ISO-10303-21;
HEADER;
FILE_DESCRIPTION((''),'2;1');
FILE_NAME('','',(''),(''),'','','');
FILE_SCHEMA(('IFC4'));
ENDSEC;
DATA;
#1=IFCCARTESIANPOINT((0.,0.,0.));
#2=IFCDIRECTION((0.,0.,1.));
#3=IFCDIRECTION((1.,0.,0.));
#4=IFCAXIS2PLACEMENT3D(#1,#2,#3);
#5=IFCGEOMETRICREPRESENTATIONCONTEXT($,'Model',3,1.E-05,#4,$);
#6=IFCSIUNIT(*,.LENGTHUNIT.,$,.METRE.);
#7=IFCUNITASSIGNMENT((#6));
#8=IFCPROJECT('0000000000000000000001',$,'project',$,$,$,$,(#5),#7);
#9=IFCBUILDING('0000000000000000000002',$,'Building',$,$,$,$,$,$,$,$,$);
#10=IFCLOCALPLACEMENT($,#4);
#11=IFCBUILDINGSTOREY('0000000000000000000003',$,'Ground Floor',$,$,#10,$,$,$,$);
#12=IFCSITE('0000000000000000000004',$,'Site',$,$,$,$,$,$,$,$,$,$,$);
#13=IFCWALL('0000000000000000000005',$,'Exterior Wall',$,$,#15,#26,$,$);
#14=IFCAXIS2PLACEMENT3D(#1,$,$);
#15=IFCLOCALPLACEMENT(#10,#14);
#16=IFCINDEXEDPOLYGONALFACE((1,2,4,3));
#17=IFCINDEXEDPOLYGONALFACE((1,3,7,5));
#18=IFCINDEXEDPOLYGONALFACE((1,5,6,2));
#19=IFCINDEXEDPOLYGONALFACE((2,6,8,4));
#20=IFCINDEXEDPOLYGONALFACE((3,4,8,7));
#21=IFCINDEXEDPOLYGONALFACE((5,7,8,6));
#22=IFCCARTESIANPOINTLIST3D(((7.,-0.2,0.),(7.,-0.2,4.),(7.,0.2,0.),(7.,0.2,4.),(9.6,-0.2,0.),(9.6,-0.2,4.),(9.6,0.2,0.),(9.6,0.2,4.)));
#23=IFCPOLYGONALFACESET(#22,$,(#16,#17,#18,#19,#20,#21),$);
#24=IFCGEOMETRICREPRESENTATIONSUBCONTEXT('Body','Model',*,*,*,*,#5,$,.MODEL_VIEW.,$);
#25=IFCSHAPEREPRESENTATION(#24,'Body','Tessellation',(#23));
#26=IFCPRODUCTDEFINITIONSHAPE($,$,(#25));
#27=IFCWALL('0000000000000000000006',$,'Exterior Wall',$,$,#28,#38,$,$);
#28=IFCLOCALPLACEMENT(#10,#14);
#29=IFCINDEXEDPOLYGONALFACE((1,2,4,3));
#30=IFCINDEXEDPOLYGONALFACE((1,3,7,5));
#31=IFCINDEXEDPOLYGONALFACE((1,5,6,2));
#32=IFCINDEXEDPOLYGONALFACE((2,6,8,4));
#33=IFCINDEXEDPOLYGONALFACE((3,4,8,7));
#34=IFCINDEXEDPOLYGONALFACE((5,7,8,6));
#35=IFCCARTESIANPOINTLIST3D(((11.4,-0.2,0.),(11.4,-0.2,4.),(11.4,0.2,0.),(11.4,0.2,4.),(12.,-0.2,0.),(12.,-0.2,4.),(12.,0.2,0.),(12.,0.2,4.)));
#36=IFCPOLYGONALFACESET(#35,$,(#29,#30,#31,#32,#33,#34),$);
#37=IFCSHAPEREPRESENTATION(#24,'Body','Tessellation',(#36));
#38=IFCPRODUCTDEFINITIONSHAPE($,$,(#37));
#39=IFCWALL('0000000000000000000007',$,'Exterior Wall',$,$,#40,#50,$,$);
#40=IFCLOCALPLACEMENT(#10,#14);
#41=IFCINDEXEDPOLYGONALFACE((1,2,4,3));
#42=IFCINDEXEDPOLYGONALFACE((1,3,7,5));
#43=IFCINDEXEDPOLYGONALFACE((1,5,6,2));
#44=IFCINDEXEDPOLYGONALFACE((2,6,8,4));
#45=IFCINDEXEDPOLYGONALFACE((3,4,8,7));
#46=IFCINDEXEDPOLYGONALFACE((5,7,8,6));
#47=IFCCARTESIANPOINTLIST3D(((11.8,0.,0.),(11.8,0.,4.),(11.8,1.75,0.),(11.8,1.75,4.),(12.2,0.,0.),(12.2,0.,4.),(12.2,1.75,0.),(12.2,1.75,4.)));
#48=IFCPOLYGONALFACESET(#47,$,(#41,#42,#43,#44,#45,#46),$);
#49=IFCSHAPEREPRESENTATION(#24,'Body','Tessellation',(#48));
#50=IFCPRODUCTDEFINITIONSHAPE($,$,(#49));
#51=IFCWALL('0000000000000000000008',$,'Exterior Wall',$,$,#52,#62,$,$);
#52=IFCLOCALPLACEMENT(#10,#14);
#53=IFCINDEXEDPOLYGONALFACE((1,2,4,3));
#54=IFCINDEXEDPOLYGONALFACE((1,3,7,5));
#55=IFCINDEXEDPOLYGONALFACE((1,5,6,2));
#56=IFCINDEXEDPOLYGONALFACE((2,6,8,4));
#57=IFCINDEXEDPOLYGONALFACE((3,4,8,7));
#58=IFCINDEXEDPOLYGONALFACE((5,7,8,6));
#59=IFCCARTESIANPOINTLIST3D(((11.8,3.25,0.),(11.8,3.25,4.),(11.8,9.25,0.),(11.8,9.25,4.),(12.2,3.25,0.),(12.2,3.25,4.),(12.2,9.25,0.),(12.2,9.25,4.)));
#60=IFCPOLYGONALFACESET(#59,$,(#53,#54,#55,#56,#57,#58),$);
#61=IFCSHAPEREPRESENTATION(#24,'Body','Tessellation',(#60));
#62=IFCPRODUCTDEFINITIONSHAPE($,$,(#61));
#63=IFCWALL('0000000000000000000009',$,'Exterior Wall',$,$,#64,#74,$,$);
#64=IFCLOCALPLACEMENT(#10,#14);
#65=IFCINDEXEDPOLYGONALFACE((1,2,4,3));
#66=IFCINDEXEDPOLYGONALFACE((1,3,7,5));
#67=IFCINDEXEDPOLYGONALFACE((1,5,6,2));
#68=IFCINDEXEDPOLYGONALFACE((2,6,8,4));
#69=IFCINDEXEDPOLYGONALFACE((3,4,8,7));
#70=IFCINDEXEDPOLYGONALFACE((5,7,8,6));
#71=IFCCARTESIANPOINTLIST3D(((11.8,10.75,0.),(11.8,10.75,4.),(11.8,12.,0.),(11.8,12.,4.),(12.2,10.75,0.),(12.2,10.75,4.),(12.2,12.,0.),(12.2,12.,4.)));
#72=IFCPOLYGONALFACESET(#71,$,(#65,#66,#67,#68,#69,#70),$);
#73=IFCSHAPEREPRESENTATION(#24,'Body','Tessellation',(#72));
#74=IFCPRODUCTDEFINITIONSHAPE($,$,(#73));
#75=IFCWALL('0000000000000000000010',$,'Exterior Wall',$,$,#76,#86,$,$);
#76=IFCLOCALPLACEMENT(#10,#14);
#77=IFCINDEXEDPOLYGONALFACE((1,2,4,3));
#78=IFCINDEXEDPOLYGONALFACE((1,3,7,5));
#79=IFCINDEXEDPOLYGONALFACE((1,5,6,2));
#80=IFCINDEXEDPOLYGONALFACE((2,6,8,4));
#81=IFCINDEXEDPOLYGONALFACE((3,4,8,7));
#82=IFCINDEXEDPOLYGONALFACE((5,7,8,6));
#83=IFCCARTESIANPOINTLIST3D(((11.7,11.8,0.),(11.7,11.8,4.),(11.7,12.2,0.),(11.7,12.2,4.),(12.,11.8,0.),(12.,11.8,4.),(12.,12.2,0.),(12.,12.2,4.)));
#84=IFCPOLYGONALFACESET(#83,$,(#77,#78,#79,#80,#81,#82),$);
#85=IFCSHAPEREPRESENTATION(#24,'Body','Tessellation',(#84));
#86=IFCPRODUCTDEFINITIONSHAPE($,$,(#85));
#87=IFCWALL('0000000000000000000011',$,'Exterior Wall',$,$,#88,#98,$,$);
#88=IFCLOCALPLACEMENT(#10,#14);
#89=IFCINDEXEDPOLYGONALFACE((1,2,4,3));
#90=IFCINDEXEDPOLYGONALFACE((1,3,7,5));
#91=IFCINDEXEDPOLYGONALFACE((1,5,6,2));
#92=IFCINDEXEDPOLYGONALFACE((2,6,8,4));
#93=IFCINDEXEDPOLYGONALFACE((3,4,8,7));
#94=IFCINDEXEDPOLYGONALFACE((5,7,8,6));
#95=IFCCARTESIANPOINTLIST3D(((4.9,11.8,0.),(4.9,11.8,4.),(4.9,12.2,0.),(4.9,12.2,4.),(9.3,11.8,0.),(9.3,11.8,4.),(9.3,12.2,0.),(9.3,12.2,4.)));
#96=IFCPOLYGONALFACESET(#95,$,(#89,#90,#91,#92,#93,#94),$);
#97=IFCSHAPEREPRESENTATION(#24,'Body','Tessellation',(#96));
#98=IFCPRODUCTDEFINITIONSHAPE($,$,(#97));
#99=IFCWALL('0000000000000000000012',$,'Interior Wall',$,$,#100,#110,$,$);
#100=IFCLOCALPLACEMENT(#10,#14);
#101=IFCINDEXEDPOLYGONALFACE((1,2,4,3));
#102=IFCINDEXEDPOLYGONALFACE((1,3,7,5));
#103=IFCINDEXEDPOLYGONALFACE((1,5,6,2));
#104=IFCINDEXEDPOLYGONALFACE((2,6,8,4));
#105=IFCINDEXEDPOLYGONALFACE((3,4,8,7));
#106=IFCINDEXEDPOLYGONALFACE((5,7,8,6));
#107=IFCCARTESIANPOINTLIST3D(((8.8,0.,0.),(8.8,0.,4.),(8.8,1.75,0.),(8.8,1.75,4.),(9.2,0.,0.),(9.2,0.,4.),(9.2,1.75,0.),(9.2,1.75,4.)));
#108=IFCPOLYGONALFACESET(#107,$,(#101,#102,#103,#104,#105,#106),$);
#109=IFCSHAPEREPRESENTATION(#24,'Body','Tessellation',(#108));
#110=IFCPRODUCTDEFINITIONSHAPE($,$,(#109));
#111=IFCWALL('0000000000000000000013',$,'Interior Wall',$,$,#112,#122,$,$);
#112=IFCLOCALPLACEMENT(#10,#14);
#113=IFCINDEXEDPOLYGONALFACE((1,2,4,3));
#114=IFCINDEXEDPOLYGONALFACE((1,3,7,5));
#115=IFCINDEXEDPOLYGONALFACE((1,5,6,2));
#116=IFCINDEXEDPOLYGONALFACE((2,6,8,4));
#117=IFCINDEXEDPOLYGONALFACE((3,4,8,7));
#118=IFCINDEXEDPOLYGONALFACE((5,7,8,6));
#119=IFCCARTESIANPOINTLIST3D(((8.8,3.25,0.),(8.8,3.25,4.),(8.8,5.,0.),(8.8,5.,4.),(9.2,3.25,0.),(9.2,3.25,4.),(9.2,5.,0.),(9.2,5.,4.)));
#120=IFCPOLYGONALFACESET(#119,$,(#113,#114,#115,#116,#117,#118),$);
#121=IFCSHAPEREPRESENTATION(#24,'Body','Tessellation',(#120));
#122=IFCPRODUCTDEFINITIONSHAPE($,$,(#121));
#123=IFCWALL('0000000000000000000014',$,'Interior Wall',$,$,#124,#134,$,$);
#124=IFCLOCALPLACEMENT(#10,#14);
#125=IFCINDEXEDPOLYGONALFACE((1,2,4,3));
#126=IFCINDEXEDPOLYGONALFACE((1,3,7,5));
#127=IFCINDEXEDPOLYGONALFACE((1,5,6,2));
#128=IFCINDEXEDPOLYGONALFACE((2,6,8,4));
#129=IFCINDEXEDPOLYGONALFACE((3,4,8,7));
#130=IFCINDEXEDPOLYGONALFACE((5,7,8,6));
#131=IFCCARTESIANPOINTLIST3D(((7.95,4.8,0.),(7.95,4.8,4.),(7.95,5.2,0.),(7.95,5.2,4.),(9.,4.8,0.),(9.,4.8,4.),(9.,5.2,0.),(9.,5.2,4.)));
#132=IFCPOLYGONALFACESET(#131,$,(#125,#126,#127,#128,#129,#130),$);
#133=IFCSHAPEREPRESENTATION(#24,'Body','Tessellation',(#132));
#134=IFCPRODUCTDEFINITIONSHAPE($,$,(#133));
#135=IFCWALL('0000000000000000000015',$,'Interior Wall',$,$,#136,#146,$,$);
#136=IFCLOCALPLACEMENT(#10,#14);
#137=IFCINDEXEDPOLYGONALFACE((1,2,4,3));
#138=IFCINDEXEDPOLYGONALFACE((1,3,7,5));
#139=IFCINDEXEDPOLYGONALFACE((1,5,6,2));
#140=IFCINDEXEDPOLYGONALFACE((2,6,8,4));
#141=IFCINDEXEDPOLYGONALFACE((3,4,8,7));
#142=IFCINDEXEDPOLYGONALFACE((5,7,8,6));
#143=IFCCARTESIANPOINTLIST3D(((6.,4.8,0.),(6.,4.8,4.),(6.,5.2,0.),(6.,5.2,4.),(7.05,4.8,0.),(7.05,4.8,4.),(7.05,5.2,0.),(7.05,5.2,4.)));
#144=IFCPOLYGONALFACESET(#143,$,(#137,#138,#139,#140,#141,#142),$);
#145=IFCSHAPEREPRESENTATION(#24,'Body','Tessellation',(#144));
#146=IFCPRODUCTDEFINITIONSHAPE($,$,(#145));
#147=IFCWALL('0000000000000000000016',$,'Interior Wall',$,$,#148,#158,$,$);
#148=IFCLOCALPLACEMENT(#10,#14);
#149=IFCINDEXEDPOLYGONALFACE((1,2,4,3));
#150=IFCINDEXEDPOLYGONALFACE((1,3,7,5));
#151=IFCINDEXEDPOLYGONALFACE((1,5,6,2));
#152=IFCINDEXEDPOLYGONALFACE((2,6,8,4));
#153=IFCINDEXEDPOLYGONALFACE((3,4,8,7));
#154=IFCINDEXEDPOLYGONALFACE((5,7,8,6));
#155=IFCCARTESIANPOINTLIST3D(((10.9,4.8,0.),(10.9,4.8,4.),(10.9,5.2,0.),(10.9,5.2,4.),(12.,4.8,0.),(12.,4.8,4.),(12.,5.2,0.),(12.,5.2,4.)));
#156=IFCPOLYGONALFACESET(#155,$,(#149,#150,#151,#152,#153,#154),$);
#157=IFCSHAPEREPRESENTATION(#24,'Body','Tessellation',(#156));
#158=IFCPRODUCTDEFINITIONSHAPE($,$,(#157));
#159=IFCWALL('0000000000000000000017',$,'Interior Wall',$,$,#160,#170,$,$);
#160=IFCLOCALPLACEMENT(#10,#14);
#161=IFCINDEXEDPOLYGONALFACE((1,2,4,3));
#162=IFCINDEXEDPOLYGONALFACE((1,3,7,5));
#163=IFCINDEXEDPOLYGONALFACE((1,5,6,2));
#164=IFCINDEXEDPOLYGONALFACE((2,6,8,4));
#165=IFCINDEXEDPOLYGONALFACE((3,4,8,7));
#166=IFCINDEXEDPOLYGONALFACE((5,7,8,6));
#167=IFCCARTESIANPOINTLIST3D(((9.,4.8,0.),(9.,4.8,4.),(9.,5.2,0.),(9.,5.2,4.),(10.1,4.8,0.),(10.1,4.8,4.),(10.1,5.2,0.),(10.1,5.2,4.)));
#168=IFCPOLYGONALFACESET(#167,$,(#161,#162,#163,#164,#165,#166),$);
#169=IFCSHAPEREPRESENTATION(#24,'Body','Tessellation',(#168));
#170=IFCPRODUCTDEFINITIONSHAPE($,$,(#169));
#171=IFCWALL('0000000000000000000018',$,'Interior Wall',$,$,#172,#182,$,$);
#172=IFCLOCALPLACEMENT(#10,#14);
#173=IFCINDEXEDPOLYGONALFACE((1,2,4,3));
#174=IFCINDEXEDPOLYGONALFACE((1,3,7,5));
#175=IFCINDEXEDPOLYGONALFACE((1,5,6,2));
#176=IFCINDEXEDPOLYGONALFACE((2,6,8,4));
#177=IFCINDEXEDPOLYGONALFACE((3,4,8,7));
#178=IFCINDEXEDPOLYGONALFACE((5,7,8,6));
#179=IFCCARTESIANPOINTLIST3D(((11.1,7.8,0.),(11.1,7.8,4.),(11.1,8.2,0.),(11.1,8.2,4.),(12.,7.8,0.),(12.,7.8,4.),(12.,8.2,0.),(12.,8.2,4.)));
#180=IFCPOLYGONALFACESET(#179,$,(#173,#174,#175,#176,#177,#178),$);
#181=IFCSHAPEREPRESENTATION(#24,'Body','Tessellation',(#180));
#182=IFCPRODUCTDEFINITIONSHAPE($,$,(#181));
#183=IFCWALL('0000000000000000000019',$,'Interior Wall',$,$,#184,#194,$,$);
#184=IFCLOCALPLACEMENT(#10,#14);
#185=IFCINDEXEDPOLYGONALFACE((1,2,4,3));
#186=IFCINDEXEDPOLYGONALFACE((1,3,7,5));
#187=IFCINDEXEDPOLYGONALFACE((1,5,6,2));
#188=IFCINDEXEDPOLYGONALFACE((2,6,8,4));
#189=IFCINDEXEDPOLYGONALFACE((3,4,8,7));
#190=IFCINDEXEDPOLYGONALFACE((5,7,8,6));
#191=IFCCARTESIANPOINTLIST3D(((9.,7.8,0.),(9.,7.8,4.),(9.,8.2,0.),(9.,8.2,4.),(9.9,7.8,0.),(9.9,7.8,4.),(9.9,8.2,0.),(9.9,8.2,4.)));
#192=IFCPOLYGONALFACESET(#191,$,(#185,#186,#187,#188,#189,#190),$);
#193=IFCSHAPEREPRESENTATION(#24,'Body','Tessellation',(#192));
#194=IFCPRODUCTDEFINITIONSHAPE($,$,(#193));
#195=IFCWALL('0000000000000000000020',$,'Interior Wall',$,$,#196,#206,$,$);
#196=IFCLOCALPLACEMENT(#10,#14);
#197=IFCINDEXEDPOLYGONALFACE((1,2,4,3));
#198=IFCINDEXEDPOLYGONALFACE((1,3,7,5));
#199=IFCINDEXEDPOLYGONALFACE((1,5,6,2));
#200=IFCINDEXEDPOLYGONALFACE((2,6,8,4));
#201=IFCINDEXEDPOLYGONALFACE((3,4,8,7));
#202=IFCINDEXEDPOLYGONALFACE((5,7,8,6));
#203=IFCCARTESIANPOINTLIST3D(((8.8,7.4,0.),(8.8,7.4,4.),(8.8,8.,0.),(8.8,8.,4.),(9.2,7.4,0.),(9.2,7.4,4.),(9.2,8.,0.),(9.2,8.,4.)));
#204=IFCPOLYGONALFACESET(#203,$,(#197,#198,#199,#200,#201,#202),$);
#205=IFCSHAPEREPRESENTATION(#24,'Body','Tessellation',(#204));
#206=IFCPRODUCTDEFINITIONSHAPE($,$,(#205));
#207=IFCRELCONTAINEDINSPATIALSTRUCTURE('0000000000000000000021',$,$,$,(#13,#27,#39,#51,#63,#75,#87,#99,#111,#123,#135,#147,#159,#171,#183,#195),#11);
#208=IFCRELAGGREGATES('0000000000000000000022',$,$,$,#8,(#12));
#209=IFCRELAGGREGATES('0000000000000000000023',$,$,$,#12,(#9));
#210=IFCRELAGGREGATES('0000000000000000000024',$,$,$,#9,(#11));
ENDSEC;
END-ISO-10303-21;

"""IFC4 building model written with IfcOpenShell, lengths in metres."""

from ifc_helpers import new_model, si_unit, frame, origin_with_axes, place, context, subcontext, project, spatial, indexed_curve, outline, extrude, element, save


model = new_model("IFC4")

# Units and contexts
model_context = context("Model", 3, precision=1e-05, world=origin_with_axes())
body_context = subcontext(model_context, "Body", "Model", "MODEL_VIEW")
ifc_project = project(units=[si_unit("LENGTHUNIT", "METRE")], contexts=[model_context])

# Site, building, storey
site = spatial("IfcSite", under=ifc_project, Name="Site")
building = spatial("IfcBuilding", under=site, Name="Building")
storey_placement = place(None, origin_with_axes())
storey = spatial("IfcBuildingStorey", under=building, at=storey_placement, Name="Ground Floor")

# Walls
wall_1_placement = place(storey_placement, frame((7.0, 0.0, 0.0), z_axis=(0.0, 0.0, 1.0), x_axis=(1.0, 0.0, 0.0)))
element("IfcWall", 1, at=wall_1_placement, inside=storey, Name="Exterior Wall", context=body_context, shape_type="SweptSolid", body=[
    extrude(outline(indexed_curve([(0.0, 0.0), (0.0, 0.4), (2.6, 0.4), (2.6, 0.0), (0.0, 0.0)], self_intersect=False)), frame((0.0, -0.2, 0.0), z_axis=(0.0, 0.0, 1.0), x_axis=(1.0, 0.0, 0.0)), (0.0, 0.0, 1.0), 4.0),
])
wall_2_placement = place(storey_placement, frame((11.4, 0.0, 0.0), z_axis=(0.0, 0.0, 1.0), x_axis=(1.0, 0.0, 0.0)))
element("IfcWall", 2, at=wall_2_placement, inside=storey, Name="Exterior Wall", context=body_context, shape_type="SweptSolid", body=[
    extrude(outline(indexed_curve([(0.0, 0.0), (0.0, 0.4), (0.6, 0.4), (0.6, 0.0), (0.0, 0.0)], self_intersect=False)), frame((0.0, -0.2, 0.0), z_axis=(0.0, 0.0, 1.0), x_axis=(1.0, 0.0, 0.0)), (0.0, 0.0, 1.0), 4.0),
])
wall_3_placement = place(storey_placement, frame((12.0, 0.0, 0.0), z_axis=(0.0, 0.0, 1.0), x_axis=(0.0, 1.0, 0.0)))
element("IfcWall", 3, at=wall_3_placement, inside=storey, Name="Exterior Wall", context=body_context, shape_type="SweptSolid", body=[
    extrude(outline(indexed_curve([(0.0, 0.0), (0.0, 0.4), (1.75, 0.4), (1.75, 0.0), (0.0, 0.0)], self_intersect=False)), frame((0.0, -0.2, 0.0), z_axis=(0.0, 0.0, 1.0), x_axis=(1.0, 0.0, 0.0)), (0.0, 0.0, 1.0), 4.0),
])
wall_4_placement = place(storey_placement, frame((12.0, 3.25, 0.0), z_axis=(0.0, 0.0, 1.0), x_axis=(0.0, 1.0, 0.0)))
element("IfcWall", 4, at=wall_4_placement, inside=storey, Name="Exterior Wall", context=body_context, shape_type="SweptSolid", body=[
    extrude(outline(indexed_curve([(0.0, 0.0), (0.0, 0.4), (6.0, 0.4), (6.0, 0.0), (0.0, 0.0)], self_intersect=False)), frame((0.0, -0.2, 0.0), z_axis=(0.0, 0.0, 1.0), x_axis=(1.0, 0.0, 0.0)), (0.0, 0.0, 1.0), 4.0),
])
wall_5_placement = place(storey_placement, frame((12.0, 10.75, 0.0), z_axis=(0.0, 0.0, 1.0), x_axis=(0.0, 1.0, 0.0)))
element("IfcWall", 5, at=wall_5_placement, inside=storey, Name="Exterior Wall", context=body_context, shape_type="SweptSolid", body=[
    extrude(outline(indexed_curve([(0.0, 0.0), (0.0, 0.4), (1.25, 0.4), (1.25, 0.0), (0.0, 0.0)], self_intersect=False)), frame((0.0, -0.2, 0.0), z_axis=(0.0, 0.0, 1.0), x_axis=(1.0, 0.0, 0.0)), (0.0, 0.0, 1.0), 4.0),
])
wall_6_placement = place(storey_placement, frame((12.0, 12.0, 0.0), z_axis=(0.0, 0.0, 1.0), x_axis=(-1.0, 0.0, 0.0)))
element("IfcWall", 6, at=wall_6_placement, inside=storey, Name="Exterior Wall", context=body_context, shape_type="SweptSolid", body=[
    extrude(outline(indexed_curve([(0.0, 0.0), (0.0, 0.4), (0.3, 0.4), (0.3, 0.0), (0.0, 0.0)], self_intersect=False)), frame((0.0, -0.2, 0.0), z_axis=(0.0, 0.0, 1.0), x_axis=(1.0, 0.0, 0.0)), (0.0, 0.0, 1.0), 4.0),
])
wall_7_placement = place(storey_placement, frame((9.3, 12.0, 0.0), z_axis=(0.0, 0.0, 1.0), x_axis=(-1.0, 0.0, 0.0)))
element("IfcWall", 7, at=wall_7_placement, inside=storey, Name="Exterior Wall", context=body_context, shape_type="SweptSolid", body=[
    extrude(outline(indexed_curve([(0.0, 0.0), (0.0, 0.4), (4.4, 0.4), (4.4, 0.0), (0.0, 0.0)], self_intersect=False)), frame((0.0, -0.2, 0.0), z_axis=(0.0, 0.0, 1.0), x_axis=(1.0, 0.0, 0.0)), (0.0, 0.0, 1.0), 4.0),
])
for number, where, z_axis, x_axis, name in (
    (8, (9.0, 0.0, 0.0), (0.0, 0.0, 1.0), (0.0, 1.0, 0.0), "Interior Wall"),
    (9, (9.0, 3.25, 0.0), (0.0, 0.0, 1.0), (0.0, 1.0, 0.0), "Interior Wall"),
):
    element("IfcWall", number, at=place(storey_placement, frame(where, z_axis=z_axis, x_axis=x_axis)), inside=storey, Name=name, context=body_context, shape_type="SweptSolid", body=[
        extrude(outline(indexed_curve([(0.0, 0.0), (0.0, 0.4), (1.75, 0.4), (1.75, 0.0), (0.0, 0.0)], self_intersect=False)), frame((0.0, -0.2, 0.0), z_axis=(0.0, 0.0, 1.0), x_axis=(1.0, 0.0, 0.0)), (0.0, 0.0, 1.0), 4.0),
    ])
for number, where, z_axis, x_axis, name in (
    (10, (9.0, 5.0, 0.0), (0.0, 0.0, 1.0), (-1.0, 0.0, 0.0), "Interior Wall"),
    (11, (7.05, 5.0, 0.0), (0.0, 0.0, 1.0), (-1.0, 0.0, 0.0), "Interior Wall"),
):
    element("IfcWall", number, at=place(storey_placement, frame(where, z_axis=z_axis, x_axis=x_axis)), inside=storey, Name=name, context=body_context, shape_type="SweptSolid", body=[
        extrude(outline(indexed_curve([(0.0, 0.0), (0.0, 0.4), (1.05, 0.4), (1.05, 0.0), (0.0, 0.0)], self_intersect=False)), frame((0.0, -0.2, 0.0), z_axis=(0.0, 0.0, 1.0), x_axis=(1.0, 0.0, 0.0)), (0.0, 0.0, 1.0), 4.0),
    ])
for number, where, z_axis, x_axis, name in (
    (12, (12.0, 5.0, 0.0), (0.0, 0.0, 1.0), (-1.0, 0.0, 0.0), "Interior Wall"),
    (13, (10.1, 5.0, 0.0), (0.0, 0.0, 1.0), (-1.0, 0.0, 0.0), "Interior Wall"),
):
    element("IfcWall", number, at=place(storey_placement, frame(where, z_axis=z_axis, x_axis=x_axis)), inside=storey, Name=name, context=body_context, shape_type="SweptSolid", body=[
        extrude(outline(indexed_curve([(0.0, 0.0), (0.0, 0.4), (1.1, 0.4), (1.1, 0.0), (0.0, 0.0)], self_intersect=False)), frame((0.0, -0.2, 0.0), z_axis=(0.0, 0.0, 1.0), x_axis=(1.0, 0.0, 0.0)), (0.0, 0.0, 1.0), 4.0),
    ])
for number, where, z_axis, x_axis, name in (
    (14, (12.0, 8.0, 0.0), (0.0, 0.0, 1.0), (-1.0, 0.0, 0.0), "Interior Wall"),
    (15, (9.9, 8.0, 0.0), (0.0, 0.0, 1.0), (-1.0, 0.0, 0.0), "Interior Wall"),
):
    element("IfcWall", number, at=place(storey_placement, frame(where, z_axis=z_axis, x_axis=x_axis)), inside=storey, Name=name, context=body_context, shape_type="SweptSolid", body=[
        extrude(outline(indexed_curve([(0.0, 0.0), (0.0, 0.4), (0.9, 0.4), (0.9, 0.0), (0.0, 0.0)], self_intersect=False)), frame((0.0, -0.2, 0.0), z_axis=(0.0, 0.0, 1.0), x_axis=(1.0, 0.0, 0.0)), (0.0, 0.0, 1.0), 4.0),
    ])
wall_8_placement = place(storey_placement, frame((9.0, 8.0, 0.0), z_axis=(0.0, 0.0, 1.0), x_axis=(0.0, -1.0, 0.0)))
element("IfcWall", 16, at=wall_8_placement, inside=storey, Name="Interior Wall", context=body_context, shape_type="SweptSolid", body=[
    extrude(outline(indexed_curve([(0.0, 0.0), (0.0, 0.4), (0.6, 0.4), (0.6, 0.0), (0.0, 0.0)], self_intersect=False)), frame((0.0, -0.2, 0.0), z_axis=(0.0, 0.0, 1.0), x_axis=(1.0, 0.0, 0.0)), (0.0, 0.0, 1.0), 4.0),
])

save(model, "model.ifc")
